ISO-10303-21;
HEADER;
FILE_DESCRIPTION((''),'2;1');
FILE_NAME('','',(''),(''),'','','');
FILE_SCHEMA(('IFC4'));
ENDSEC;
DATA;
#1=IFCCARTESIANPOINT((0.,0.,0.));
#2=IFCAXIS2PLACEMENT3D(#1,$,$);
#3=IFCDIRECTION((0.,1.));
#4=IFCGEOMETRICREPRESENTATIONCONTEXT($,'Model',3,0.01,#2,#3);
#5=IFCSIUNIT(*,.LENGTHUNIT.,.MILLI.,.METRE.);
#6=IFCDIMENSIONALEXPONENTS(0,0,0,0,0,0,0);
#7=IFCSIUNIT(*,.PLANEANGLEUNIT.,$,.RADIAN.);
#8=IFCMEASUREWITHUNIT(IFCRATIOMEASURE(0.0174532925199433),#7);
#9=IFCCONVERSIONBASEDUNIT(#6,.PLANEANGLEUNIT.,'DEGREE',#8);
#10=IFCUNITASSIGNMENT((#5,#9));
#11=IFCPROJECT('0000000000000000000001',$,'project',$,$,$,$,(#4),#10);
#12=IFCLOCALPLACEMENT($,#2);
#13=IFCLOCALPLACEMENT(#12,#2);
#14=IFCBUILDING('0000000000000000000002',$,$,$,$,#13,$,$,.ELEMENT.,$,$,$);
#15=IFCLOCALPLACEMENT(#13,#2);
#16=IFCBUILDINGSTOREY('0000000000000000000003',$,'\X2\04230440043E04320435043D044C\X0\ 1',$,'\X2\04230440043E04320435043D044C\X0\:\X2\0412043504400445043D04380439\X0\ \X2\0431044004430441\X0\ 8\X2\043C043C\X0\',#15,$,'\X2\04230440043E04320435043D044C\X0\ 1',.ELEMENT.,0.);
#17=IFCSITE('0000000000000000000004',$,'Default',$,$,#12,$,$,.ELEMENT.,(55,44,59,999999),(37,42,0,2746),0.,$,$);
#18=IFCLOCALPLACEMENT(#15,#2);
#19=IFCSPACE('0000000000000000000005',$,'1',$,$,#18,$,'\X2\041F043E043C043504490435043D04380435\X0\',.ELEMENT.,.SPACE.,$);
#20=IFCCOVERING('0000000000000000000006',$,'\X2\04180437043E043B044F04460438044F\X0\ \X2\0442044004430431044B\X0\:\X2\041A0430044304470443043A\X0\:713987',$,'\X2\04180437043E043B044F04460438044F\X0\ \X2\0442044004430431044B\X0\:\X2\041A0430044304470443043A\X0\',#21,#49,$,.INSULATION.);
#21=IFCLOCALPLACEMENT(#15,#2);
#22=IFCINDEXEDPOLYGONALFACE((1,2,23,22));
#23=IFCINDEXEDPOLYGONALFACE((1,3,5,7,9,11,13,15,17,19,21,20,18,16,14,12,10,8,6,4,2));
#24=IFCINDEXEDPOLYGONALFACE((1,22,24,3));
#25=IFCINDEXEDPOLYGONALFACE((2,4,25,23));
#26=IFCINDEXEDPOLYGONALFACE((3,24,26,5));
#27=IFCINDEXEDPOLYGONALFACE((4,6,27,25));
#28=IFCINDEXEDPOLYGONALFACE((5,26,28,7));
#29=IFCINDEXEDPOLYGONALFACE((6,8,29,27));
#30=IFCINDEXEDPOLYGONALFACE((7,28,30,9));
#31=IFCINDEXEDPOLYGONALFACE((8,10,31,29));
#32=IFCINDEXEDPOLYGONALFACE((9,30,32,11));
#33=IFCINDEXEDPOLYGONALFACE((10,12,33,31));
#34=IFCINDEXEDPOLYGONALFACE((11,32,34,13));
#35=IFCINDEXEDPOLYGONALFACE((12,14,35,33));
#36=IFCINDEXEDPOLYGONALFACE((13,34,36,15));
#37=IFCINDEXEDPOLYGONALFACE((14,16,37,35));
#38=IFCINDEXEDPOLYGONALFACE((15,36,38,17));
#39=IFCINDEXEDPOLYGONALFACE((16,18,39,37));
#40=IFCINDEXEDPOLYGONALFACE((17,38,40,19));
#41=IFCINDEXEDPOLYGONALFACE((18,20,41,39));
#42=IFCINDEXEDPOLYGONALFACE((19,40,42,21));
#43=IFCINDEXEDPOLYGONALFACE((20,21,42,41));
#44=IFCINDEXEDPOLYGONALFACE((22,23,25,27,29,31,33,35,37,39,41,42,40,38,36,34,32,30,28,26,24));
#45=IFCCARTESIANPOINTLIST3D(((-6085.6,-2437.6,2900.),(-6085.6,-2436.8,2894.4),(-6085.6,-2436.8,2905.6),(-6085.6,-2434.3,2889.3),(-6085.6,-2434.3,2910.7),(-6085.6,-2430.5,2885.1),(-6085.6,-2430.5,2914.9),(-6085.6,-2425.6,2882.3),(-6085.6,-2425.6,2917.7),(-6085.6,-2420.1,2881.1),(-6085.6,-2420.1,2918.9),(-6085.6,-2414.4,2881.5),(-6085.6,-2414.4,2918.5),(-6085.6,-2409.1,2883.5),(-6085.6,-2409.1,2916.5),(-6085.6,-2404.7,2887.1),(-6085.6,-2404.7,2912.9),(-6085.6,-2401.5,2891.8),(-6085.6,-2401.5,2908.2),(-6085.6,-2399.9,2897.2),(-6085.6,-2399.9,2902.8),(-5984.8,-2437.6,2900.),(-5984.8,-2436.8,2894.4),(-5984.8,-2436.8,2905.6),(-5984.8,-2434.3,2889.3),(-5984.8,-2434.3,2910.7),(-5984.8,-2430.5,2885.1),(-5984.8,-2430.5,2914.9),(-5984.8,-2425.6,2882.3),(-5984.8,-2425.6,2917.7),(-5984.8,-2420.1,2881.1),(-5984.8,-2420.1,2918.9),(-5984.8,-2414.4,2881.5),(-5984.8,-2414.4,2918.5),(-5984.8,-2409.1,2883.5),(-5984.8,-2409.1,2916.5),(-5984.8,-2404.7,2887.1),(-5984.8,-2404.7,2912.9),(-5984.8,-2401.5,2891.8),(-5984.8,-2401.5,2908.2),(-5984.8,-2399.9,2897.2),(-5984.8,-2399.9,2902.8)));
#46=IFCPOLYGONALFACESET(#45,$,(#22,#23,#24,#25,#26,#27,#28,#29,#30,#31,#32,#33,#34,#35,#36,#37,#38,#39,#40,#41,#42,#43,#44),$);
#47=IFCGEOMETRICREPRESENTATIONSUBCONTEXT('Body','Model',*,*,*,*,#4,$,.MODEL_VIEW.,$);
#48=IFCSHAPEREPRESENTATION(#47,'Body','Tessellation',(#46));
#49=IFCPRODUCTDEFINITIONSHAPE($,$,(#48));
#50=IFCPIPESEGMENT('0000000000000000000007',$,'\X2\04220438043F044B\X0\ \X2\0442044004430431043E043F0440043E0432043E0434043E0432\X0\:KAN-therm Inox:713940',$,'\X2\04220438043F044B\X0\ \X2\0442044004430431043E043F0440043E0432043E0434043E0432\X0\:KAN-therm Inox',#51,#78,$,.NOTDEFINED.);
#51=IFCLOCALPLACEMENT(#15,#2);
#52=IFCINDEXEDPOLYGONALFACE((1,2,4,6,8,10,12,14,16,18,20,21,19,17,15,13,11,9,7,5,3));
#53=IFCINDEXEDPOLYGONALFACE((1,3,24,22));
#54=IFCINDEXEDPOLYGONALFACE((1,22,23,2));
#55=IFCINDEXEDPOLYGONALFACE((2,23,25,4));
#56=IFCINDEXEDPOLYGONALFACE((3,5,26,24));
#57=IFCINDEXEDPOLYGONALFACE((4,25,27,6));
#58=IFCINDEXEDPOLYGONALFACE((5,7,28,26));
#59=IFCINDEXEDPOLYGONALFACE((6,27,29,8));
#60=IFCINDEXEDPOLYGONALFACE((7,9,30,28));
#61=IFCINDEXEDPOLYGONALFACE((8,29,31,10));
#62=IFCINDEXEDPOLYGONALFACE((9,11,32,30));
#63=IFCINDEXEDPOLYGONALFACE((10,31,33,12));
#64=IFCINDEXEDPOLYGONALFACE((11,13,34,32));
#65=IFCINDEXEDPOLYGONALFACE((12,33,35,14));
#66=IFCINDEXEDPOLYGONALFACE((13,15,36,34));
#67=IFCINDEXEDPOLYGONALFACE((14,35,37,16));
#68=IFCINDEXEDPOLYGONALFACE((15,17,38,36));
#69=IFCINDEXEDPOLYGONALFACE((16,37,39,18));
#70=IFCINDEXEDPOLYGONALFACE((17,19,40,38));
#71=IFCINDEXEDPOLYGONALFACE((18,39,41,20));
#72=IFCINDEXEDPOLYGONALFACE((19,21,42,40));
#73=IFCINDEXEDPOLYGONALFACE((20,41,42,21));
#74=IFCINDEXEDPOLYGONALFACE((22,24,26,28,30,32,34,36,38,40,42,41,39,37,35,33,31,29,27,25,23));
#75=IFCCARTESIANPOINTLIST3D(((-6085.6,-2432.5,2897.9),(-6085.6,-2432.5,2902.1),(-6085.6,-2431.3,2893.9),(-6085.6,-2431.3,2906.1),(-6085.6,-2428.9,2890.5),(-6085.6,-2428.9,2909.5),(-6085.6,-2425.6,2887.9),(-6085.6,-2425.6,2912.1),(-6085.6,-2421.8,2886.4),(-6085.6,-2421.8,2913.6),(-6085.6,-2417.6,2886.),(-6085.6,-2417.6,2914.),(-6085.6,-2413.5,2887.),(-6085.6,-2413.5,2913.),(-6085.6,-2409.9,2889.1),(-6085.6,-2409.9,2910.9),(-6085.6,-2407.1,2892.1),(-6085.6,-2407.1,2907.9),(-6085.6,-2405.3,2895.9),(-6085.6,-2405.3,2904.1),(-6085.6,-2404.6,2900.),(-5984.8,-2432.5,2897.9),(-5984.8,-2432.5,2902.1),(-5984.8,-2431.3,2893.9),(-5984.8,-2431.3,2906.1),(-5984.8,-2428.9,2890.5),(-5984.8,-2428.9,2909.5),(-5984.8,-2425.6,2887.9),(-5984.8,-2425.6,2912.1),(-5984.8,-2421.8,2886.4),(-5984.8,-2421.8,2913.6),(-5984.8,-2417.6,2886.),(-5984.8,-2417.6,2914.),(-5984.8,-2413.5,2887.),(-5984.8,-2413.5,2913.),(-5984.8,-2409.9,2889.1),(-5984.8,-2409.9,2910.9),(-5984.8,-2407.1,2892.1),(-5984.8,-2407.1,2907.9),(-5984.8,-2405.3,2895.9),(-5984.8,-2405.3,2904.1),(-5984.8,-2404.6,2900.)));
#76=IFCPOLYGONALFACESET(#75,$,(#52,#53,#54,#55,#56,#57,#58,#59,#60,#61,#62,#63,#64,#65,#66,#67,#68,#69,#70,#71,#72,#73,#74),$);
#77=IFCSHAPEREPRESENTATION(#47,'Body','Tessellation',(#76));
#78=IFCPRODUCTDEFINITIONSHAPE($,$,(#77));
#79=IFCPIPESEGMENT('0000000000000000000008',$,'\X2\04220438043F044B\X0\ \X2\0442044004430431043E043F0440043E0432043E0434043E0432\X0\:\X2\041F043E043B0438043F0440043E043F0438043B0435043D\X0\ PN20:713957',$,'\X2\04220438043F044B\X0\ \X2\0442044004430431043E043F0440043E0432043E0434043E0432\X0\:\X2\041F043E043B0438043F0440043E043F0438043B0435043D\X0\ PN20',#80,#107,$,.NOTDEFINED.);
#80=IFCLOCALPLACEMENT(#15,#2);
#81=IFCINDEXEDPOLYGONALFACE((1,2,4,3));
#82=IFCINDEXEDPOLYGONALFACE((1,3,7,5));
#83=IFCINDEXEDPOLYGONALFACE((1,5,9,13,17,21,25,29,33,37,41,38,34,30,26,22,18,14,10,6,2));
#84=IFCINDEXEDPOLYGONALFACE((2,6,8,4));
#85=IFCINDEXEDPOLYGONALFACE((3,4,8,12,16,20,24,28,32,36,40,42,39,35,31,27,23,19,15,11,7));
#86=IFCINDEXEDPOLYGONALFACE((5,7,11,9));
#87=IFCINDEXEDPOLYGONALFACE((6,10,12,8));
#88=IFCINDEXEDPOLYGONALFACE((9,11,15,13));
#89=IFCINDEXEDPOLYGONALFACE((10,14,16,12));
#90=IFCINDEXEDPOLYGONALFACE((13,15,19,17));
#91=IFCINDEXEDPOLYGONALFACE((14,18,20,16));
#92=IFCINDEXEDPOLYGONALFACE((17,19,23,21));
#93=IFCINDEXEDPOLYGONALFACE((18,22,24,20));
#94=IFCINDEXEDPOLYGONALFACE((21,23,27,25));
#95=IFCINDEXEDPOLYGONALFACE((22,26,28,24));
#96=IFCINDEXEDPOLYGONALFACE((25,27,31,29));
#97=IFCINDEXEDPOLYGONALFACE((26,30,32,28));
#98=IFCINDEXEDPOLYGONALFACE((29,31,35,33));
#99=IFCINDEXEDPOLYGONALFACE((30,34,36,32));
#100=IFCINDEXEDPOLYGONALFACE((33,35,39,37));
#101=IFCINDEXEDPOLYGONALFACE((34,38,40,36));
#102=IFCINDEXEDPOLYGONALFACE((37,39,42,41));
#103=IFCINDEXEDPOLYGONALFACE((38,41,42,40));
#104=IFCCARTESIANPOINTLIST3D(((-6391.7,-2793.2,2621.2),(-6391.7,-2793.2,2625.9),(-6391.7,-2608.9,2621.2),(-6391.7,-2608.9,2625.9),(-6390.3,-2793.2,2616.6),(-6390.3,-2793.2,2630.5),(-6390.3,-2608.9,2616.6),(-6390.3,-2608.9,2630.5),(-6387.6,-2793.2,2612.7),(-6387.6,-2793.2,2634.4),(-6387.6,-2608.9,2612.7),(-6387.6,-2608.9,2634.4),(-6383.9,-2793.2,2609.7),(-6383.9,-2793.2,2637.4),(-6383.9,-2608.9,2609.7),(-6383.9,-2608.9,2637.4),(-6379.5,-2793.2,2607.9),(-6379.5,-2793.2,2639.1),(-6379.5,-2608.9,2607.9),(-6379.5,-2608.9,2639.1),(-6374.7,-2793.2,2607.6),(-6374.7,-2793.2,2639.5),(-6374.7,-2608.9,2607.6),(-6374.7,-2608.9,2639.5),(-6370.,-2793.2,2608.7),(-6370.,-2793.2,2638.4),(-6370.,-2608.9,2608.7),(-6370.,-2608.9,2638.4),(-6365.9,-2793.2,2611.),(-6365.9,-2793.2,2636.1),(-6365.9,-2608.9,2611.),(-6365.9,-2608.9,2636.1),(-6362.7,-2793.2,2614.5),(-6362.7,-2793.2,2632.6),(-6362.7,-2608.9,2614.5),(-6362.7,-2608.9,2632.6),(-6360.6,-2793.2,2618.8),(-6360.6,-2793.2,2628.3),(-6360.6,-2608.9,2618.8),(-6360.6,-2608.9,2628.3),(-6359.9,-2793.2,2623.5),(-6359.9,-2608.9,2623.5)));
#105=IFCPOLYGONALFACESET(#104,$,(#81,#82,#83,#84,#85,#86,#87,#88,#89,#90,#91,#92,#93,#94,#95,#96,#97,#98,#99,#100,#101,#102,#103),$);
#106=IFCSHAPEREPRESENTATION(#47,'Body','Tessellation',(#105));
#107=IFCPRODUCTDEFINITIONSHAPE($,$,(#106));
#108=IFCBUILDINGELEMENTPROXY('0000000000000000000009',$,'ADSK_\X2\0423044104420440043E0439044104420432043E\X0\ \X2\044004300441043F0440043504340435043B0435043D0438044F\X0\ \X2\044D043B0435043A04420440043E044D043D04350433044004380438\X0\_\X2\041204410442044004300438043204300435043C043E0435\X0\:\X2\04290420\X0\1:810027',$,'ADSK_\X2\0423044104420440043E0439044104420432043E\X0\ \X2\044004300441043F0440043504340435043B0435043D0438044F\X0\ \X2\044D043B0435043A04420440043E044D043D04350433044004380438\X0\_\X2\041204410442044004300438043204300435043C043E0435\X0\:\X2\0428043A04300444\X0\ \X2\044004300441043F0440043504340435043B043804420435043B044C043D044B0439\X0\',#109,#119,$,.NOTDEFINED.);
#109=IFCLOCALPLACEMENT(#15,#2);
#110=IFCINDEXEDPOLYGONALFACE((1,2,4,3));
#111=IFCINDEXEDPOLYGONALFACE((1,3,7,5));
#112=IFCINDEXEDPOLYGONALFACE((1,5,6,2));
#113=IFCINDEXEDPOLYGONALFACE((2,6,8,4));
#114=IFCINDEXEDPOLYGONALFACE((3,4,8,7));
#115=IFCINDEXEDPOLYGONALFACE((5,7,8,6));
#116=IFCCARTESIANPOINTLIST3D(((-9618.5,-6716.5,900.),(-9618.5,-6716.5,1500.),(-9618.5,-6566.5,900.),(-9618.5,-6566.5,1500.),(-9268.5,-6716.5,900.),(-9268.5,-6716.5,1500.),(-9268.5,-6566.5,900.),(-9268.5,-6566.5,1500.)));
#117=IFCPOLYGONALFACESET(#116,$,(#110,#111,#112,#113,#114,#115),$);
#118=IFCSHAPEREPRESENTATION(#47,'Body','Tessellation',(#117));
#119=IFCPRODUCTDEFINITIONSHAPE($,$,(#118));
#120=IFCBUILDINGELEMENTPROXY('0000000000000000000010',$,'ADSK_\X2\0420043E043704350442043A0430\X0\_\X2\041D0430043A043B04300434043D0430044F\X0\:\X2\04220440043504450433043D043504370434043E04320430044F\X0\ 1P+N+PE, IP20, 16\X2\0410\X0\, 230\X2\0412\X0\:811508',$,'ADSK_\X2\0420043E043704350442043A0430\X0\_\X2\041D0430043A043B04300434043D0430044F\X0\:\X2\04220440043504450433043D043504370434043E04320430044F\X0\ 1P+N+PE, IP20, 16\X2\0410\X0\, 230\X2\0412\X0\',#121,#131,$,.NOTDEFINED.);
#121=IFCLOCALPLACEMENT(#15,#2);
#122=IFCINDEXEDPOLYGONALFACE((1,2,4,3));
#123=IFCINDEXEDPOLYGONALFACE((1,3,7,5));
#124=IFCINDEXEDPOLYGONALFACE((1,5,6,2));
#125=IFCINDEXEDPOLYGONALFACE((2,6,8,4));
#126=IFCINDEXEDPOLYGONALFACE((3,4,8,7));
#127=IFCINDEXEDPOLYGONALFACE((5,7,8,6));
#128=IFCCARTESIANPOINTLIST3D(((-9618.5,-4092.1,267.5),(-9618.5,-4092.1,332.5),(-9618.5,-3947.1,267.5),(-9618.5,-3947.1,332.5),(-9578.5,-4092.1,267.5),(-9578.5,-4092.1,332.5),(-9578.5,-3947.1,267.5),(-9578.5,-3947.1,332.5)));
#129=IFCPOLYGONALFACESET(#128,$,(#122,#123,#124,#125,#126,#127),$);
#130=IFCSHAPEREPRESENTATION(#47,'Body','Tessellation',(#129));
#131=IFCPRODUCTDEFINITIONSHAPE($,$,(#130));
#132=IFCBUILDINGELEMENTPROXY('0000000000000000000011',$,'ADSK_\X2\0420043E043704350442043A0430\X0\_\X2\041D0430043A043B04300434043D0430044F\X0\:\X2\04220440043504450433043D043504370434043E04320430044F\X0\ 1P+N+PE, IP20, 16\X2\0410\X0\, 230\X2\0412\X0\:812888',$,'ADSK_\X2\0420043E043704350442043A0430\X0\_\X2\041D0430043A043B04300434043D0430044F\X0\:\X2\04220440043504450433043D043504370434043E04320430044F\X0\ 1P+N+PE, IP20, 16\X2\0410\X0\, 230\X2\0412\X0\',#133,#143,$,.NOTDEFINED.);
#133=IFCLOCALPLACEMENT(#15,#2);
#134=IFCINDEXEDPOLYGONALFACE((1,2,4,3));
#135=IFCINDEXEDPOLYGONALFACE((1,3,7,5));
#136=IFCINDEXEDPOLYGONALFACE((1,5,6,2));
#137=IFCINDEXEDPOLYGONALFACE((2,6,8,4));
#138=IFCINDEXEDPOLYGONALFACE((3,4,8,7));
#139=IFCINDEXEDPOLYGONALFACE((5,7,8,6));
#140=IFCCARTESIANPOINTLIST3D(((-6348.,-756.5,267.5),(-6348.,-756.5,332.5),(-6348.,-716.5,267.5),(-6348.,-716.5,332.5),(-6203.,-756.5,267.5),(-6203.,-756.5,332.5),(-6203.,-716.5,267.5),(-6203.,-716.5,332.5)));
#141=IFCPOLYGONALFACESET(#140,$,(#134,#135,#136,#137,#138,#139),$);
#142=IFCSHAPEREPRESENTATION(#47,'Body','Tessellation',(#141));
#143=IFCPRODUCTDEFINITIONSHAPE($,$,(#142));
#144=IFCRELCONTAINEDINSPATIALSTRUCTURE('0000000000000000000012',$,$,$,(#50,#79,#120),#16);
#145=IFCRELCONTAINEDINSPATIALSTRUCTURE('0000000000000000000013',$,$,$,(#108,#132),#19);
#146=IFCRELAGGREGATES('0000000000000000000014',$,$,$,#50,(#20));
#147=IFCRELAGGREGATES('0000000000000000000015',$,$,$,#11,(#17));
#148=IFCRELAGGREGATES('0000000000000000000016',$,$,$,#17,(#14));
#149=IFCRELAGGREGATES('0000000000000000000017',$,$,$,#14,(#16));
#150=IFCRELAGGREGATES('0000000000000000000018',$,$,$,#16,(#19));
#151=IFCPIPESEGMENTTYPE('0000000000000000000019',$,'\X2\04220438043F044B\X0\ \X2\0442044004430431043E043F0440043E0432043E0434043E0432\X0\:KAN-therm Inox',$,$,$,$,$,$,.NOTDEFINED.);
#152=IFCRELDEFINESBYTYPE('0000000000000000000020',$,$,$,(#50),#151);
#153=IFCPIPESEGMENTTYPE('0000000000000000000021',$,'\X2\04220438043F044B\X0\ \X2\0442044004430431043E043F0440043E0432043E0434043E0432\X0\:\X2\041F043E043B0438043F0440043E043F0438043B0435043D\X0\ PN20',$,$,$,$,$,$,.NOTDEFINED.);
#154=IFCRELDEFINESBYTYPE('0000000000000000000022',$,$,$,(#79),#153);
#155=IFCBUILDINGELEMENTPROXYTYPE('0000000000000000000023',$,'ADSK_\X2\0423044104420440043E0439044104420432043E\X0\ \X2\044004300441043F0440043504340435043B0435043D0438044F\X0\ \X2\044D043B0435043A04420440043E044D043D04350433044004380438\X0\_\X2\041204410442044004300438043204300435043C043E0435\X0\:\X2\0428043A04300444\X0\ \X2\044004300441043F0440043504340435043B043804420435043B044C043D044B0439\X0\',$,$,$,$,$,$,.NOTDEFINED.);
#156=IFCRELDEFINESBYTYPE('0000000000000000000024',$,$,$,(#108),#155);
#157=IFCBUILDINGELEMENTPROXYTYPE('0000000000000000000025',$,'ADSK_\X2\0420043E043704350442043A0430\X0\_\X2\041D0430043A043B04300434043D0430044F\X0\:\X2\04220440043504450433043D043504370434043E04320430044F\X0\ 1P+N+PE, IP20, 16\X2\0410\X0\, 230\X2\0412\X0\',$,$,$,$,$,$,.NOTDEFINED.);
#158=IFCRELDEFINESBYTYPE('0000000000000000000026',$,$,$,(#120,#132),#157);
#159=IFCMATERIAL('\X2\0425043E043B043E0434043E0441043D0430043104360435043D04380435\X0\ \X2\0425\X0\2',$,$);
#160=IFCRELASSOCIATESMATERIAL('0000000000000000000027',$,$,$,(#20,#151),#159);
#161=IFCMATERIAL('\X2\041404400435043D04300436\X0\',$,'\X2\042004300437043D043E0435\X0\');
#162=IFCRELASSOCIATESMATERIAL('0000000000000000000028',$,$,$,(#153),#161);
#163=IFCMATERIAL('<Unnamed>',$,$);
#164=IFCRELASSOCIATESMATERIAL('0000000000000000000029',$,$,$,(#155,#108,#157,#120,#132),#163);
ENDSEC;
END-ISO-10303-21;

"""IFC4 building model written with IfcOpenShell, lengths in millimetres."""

from ifc_helpers import new_model, entity, si_unit, converted_unit, direction, frame, frame_2d, origin, origin_2d_with_axis, place, context, subcontext, project, spatial, rectangle, circle, extrude, source, transform, mapped, material, type_object, type_shapes, element, aggregate, save


model = new_model("IFC4")

# Units and contexts
model_context = context("Model", 3, precision=0.01, world=origin(), true_north=direction((0.0, 1.0)))
body_context = subcontext(model_context, "Body", "Model", "MODEL_VIEW")
ifc_project = project(units=[si_unit("LENGTHUNIT", "METRE", prefix="MILLI"), converted_unit("PLANEANGLEUNIT", "DEGREE", entity("IfcRatioMeasure", 0.0174532925199433), si_unit("PLANEANGLEUNIT", "RADIAN"), dimensions=[0, 0, 0, 0, 0, 0, 0])], contexts=[model_context])

# Site, building, storey
site_placement = place(None, origin())
site = spatial("IfcSite", under=ifc_project, at=site_placement, Name="Default", CompositionType="ELEMENT", RefLatitude=(55, 44, 59, 999999), RefLongitude=(37, 42, 0, 2746), RefElevation=0.0)
building_placement = place(site_placement, origin())
building = spatial("IfcBuilding", under=site, at=building_placement, CompositionType="ELEMENT")
storey_placement = place(building_placement, origin())
storey = spatial("IfcBuildingStorey", under=building, at=storey_placement, Name="Уровень 1", ObjectType="Уровень:Верхний брус 8мм", LongName="Уровень 1", CompositionType="ELEMENT", Elevation=0.0)

# Covering
ifc_material_1 = material(Name="Холодоснабжение Х2")
covering_1_placement = place(storey_placement, frame((-6085.6, -2439.2, 2879.4)))
covering_1 = element("IfcCovering", 1, at=covering_1_placement, material=ifc_material_1, Name="Изоляция трубы:Каучук:713987", ObjectType="Изоляция трубы:Каучук", PredefinedType="INSULATION", context=body_context, shape_type="SweptSolid", body=[
    extrude(circle(Radius=19.0, at=frame_2d((0.0, 0.0), x_axis=(1.0, 0.0))), frame((0.0, 20.6, 20.6), z_axis=(1.0, 0.0, 0.0), x_axis=(0.0, -1.0, 0.0)), (0.0, 0.0, 1.0), 100.8),
])

# Pipe segment
pipe_segment_type_1 = type_object("IfcPipeSegmentType", Name="Типы трубопроводов:KAN-therm Inox", PredefinedType="NOTDEFINED", material=ifc_material_1)
pipe_segment_1_placement = place(storey_placement, frame((-6085.6, -2434.2, 2884.4)))
pipe_segment_1 = element("IfcPipeSegment", 2, at=pipe_segment_1_placement, inside=storey, type_object=pipe_segment_type_1, Name="Типы трубопроводов:KAN-therm Inox:713940", ObjectType="Типы трубопроводов:KAN-therm Inox", PredefinedType="NOTDEFINED", context=body_context, shape_type="SweptSolid", body=[
    extrude(circle(Radius=14.0, at=origin_2d_with_axis()), frame((0.0, 15.6, 15.6), z_axis=(1.0, 0.0, 0.0), x_axis=(0.0, 1.0, 0.0)), (0.0, 0.0, 1.0), 100.8),
])
aggregate(pipe_segment_1, [covering_1])

# Pipe segment
ifc_material_2 = material(Name="Дренаж", Category="Разное")
pipe_segment_type_2 = type_object("IfcPipeSegmentType", Name="Типы трубопроводов:Полипропилен PN20", PredefinedType="NOTDEFINED", material=ifc_material_2)
pipe_segment_2_placement = place(storey_placement, frame((-6393.5, -2793.2, 2606.0)))
element("IfcPipeSegment", 3, at=pipe_segment_2_placement, inside=storey, type_object=pipe_segment_type_2, Name="Типы трубопроводов:Полипропилен PN20:713957", ObjectType="Типы трубопроводов:Полипропилен PN20", PredefinedType="NOTDEFINED", context=body_context, shape_type="SweptSolid", body=[
    extrude(circle(Radius=16.0, at=frame_2d((0.0, 0.0), x_axis=(1.0, 0.0))), frame((17.6, 0.0, 17.6), z_axis=(-0.000002, 1.0, 0.0), x_axis=(1.0, 0.000002, 0.0)), (0.0, 0.0, 1.0), 184.3),
])

# Shared definitions
space_placement = place(storey_placement, origin())
space = spatial("IfcSpace", under=storey, at=space_placement, Name="1", LongName="Помещение", CompositionType="ELEMENT", PredefinedType="SPACE")

# Building element proxies
ifc_material_3 = material(Name="<Unnamed>")
building_element_proxy_type_1 = type_object("IfcBuildingElementProxyType", Name="ADSK_Устройство распределения электроэнегрии_Встраиваемое:Шкаф распределительный", PredefinedType="NOTDEFINED", material=ifc_material_3)
shared_shape_1 = source(origin(), body_context, "Body", "SweptSolid", [
    extrude(rectangle(XDim=150.0, YDim=350.0, at=origin_2d_with_axis()), frame((0.0, -75.0, -600.0), z_axis=(0.0, 0.0, 1.0), x_axis=(0.0, 1.0, 0.0)), (0.0, 0.0, 1.0), 600.0),
])
type_shapes(building_element_proxy_type_1, [shared_shape_1])
proxy_1_placement = place(space_placement, frame((-9443.5, -6566.5, 1500.0)))
element("IfcBuildingElementProxy", 4, at=proxy_1_placement, inside=space, type_object=building_element_proxy_type_1, material=ifc_material_3, Name="ADSK_Устройство распределения электроэнегрии_Встраиваемое:ЩР1:810027", ObjectType="ADSK_Устройство распределения электроэнегрии_Встраиваемое:Шкаф распределительный", PredefinedType="NOTDEFINED", context=body_context, shape_type="MappedRepresentation", body=[
    mapped(shared_shape_1, transform((0.0, 0.0, 0.0), scale=1.0)),
])
building_element_proxy_type_2 = type_object("IfcBuildingElementProxyType", Name="ADSK_Розетка_Накладная:Трехгнездовая 1P+N+PE, IP20, 16А, 230В", PredefinedType="NOTDEFINED", material=ifc_material_3)
shared_shape_2 = source(origin(), body_context, "Body", "SweptSolid", [
    extrude(rectangle(XDim=145.0, YDim=40.0, at=origin_2d_with_axis()), frame((0.0, 20.0, -32.5), z_axis=(0.0, 0.0, 1.0), x_axis=(-1.0, 0.0, 0.0)), (0.0, 0.0, 1.0), 65.0),
])
type_shapes(building_element_proxy_type_2, [shared_shape_2])
proxy_2_placement = place(storey_placement, frame((-9578.5, -4019.6, 300.0), z_axis=(0.0, 0.0, 1.0), x_axis=(0.0, 1.0, 0.0)))
element("IfcBuildingElementProxy", 5, at=proxy_2_placement, inside=storey, type_object=building_element_proxy_type_2, material=ifc_material_3, Name="ADSK_Розетка_Накладная:Трехгнездовая 1P+N+PE, IP20, 16А, 230В:811508", ObjectType="ADSK_Розетка_Накладная:Трехгнездовая 1P+N+PE, IP20, 16А, 230В", PredefinedType="NOTDEFINED", context=body_context, shape_type="MappedRepresentation", body=[
    mapped(shared_shape_2, transform((0.0, 0.0, 0.0), scale=1.0)),
])
proxy_3_placement = place(space_placement, frame((-6275.5, -716.5, 300.0), z_axis=(0.0, 0.0, 1.0), x_axis=(-1.0, 0.0, 0.0)))
element("IfcBuildingElementProxy", 6, at=proxy_3_placement, inside=space, type_object=building_element_proxy_type_2, material=ifc_material_3, Name="ADSK_Розетка_Накладная:Трехгнездовая 1P+N+PE, IP20, 16А, 230В:812888", ObjectType="ADSK_Розетка_Накладная:Трехгнездовая 1P+N+PE, IP20, 16А, 230В", PredefinedType="NOTDEFINED", context=body_context, shape_type="MappedRepresentation", body=[
    mapped(shared_shape_2, transform((0.0, 0.0, 0.0), scale=1.0)),
])

save(model, "model.ifc")
